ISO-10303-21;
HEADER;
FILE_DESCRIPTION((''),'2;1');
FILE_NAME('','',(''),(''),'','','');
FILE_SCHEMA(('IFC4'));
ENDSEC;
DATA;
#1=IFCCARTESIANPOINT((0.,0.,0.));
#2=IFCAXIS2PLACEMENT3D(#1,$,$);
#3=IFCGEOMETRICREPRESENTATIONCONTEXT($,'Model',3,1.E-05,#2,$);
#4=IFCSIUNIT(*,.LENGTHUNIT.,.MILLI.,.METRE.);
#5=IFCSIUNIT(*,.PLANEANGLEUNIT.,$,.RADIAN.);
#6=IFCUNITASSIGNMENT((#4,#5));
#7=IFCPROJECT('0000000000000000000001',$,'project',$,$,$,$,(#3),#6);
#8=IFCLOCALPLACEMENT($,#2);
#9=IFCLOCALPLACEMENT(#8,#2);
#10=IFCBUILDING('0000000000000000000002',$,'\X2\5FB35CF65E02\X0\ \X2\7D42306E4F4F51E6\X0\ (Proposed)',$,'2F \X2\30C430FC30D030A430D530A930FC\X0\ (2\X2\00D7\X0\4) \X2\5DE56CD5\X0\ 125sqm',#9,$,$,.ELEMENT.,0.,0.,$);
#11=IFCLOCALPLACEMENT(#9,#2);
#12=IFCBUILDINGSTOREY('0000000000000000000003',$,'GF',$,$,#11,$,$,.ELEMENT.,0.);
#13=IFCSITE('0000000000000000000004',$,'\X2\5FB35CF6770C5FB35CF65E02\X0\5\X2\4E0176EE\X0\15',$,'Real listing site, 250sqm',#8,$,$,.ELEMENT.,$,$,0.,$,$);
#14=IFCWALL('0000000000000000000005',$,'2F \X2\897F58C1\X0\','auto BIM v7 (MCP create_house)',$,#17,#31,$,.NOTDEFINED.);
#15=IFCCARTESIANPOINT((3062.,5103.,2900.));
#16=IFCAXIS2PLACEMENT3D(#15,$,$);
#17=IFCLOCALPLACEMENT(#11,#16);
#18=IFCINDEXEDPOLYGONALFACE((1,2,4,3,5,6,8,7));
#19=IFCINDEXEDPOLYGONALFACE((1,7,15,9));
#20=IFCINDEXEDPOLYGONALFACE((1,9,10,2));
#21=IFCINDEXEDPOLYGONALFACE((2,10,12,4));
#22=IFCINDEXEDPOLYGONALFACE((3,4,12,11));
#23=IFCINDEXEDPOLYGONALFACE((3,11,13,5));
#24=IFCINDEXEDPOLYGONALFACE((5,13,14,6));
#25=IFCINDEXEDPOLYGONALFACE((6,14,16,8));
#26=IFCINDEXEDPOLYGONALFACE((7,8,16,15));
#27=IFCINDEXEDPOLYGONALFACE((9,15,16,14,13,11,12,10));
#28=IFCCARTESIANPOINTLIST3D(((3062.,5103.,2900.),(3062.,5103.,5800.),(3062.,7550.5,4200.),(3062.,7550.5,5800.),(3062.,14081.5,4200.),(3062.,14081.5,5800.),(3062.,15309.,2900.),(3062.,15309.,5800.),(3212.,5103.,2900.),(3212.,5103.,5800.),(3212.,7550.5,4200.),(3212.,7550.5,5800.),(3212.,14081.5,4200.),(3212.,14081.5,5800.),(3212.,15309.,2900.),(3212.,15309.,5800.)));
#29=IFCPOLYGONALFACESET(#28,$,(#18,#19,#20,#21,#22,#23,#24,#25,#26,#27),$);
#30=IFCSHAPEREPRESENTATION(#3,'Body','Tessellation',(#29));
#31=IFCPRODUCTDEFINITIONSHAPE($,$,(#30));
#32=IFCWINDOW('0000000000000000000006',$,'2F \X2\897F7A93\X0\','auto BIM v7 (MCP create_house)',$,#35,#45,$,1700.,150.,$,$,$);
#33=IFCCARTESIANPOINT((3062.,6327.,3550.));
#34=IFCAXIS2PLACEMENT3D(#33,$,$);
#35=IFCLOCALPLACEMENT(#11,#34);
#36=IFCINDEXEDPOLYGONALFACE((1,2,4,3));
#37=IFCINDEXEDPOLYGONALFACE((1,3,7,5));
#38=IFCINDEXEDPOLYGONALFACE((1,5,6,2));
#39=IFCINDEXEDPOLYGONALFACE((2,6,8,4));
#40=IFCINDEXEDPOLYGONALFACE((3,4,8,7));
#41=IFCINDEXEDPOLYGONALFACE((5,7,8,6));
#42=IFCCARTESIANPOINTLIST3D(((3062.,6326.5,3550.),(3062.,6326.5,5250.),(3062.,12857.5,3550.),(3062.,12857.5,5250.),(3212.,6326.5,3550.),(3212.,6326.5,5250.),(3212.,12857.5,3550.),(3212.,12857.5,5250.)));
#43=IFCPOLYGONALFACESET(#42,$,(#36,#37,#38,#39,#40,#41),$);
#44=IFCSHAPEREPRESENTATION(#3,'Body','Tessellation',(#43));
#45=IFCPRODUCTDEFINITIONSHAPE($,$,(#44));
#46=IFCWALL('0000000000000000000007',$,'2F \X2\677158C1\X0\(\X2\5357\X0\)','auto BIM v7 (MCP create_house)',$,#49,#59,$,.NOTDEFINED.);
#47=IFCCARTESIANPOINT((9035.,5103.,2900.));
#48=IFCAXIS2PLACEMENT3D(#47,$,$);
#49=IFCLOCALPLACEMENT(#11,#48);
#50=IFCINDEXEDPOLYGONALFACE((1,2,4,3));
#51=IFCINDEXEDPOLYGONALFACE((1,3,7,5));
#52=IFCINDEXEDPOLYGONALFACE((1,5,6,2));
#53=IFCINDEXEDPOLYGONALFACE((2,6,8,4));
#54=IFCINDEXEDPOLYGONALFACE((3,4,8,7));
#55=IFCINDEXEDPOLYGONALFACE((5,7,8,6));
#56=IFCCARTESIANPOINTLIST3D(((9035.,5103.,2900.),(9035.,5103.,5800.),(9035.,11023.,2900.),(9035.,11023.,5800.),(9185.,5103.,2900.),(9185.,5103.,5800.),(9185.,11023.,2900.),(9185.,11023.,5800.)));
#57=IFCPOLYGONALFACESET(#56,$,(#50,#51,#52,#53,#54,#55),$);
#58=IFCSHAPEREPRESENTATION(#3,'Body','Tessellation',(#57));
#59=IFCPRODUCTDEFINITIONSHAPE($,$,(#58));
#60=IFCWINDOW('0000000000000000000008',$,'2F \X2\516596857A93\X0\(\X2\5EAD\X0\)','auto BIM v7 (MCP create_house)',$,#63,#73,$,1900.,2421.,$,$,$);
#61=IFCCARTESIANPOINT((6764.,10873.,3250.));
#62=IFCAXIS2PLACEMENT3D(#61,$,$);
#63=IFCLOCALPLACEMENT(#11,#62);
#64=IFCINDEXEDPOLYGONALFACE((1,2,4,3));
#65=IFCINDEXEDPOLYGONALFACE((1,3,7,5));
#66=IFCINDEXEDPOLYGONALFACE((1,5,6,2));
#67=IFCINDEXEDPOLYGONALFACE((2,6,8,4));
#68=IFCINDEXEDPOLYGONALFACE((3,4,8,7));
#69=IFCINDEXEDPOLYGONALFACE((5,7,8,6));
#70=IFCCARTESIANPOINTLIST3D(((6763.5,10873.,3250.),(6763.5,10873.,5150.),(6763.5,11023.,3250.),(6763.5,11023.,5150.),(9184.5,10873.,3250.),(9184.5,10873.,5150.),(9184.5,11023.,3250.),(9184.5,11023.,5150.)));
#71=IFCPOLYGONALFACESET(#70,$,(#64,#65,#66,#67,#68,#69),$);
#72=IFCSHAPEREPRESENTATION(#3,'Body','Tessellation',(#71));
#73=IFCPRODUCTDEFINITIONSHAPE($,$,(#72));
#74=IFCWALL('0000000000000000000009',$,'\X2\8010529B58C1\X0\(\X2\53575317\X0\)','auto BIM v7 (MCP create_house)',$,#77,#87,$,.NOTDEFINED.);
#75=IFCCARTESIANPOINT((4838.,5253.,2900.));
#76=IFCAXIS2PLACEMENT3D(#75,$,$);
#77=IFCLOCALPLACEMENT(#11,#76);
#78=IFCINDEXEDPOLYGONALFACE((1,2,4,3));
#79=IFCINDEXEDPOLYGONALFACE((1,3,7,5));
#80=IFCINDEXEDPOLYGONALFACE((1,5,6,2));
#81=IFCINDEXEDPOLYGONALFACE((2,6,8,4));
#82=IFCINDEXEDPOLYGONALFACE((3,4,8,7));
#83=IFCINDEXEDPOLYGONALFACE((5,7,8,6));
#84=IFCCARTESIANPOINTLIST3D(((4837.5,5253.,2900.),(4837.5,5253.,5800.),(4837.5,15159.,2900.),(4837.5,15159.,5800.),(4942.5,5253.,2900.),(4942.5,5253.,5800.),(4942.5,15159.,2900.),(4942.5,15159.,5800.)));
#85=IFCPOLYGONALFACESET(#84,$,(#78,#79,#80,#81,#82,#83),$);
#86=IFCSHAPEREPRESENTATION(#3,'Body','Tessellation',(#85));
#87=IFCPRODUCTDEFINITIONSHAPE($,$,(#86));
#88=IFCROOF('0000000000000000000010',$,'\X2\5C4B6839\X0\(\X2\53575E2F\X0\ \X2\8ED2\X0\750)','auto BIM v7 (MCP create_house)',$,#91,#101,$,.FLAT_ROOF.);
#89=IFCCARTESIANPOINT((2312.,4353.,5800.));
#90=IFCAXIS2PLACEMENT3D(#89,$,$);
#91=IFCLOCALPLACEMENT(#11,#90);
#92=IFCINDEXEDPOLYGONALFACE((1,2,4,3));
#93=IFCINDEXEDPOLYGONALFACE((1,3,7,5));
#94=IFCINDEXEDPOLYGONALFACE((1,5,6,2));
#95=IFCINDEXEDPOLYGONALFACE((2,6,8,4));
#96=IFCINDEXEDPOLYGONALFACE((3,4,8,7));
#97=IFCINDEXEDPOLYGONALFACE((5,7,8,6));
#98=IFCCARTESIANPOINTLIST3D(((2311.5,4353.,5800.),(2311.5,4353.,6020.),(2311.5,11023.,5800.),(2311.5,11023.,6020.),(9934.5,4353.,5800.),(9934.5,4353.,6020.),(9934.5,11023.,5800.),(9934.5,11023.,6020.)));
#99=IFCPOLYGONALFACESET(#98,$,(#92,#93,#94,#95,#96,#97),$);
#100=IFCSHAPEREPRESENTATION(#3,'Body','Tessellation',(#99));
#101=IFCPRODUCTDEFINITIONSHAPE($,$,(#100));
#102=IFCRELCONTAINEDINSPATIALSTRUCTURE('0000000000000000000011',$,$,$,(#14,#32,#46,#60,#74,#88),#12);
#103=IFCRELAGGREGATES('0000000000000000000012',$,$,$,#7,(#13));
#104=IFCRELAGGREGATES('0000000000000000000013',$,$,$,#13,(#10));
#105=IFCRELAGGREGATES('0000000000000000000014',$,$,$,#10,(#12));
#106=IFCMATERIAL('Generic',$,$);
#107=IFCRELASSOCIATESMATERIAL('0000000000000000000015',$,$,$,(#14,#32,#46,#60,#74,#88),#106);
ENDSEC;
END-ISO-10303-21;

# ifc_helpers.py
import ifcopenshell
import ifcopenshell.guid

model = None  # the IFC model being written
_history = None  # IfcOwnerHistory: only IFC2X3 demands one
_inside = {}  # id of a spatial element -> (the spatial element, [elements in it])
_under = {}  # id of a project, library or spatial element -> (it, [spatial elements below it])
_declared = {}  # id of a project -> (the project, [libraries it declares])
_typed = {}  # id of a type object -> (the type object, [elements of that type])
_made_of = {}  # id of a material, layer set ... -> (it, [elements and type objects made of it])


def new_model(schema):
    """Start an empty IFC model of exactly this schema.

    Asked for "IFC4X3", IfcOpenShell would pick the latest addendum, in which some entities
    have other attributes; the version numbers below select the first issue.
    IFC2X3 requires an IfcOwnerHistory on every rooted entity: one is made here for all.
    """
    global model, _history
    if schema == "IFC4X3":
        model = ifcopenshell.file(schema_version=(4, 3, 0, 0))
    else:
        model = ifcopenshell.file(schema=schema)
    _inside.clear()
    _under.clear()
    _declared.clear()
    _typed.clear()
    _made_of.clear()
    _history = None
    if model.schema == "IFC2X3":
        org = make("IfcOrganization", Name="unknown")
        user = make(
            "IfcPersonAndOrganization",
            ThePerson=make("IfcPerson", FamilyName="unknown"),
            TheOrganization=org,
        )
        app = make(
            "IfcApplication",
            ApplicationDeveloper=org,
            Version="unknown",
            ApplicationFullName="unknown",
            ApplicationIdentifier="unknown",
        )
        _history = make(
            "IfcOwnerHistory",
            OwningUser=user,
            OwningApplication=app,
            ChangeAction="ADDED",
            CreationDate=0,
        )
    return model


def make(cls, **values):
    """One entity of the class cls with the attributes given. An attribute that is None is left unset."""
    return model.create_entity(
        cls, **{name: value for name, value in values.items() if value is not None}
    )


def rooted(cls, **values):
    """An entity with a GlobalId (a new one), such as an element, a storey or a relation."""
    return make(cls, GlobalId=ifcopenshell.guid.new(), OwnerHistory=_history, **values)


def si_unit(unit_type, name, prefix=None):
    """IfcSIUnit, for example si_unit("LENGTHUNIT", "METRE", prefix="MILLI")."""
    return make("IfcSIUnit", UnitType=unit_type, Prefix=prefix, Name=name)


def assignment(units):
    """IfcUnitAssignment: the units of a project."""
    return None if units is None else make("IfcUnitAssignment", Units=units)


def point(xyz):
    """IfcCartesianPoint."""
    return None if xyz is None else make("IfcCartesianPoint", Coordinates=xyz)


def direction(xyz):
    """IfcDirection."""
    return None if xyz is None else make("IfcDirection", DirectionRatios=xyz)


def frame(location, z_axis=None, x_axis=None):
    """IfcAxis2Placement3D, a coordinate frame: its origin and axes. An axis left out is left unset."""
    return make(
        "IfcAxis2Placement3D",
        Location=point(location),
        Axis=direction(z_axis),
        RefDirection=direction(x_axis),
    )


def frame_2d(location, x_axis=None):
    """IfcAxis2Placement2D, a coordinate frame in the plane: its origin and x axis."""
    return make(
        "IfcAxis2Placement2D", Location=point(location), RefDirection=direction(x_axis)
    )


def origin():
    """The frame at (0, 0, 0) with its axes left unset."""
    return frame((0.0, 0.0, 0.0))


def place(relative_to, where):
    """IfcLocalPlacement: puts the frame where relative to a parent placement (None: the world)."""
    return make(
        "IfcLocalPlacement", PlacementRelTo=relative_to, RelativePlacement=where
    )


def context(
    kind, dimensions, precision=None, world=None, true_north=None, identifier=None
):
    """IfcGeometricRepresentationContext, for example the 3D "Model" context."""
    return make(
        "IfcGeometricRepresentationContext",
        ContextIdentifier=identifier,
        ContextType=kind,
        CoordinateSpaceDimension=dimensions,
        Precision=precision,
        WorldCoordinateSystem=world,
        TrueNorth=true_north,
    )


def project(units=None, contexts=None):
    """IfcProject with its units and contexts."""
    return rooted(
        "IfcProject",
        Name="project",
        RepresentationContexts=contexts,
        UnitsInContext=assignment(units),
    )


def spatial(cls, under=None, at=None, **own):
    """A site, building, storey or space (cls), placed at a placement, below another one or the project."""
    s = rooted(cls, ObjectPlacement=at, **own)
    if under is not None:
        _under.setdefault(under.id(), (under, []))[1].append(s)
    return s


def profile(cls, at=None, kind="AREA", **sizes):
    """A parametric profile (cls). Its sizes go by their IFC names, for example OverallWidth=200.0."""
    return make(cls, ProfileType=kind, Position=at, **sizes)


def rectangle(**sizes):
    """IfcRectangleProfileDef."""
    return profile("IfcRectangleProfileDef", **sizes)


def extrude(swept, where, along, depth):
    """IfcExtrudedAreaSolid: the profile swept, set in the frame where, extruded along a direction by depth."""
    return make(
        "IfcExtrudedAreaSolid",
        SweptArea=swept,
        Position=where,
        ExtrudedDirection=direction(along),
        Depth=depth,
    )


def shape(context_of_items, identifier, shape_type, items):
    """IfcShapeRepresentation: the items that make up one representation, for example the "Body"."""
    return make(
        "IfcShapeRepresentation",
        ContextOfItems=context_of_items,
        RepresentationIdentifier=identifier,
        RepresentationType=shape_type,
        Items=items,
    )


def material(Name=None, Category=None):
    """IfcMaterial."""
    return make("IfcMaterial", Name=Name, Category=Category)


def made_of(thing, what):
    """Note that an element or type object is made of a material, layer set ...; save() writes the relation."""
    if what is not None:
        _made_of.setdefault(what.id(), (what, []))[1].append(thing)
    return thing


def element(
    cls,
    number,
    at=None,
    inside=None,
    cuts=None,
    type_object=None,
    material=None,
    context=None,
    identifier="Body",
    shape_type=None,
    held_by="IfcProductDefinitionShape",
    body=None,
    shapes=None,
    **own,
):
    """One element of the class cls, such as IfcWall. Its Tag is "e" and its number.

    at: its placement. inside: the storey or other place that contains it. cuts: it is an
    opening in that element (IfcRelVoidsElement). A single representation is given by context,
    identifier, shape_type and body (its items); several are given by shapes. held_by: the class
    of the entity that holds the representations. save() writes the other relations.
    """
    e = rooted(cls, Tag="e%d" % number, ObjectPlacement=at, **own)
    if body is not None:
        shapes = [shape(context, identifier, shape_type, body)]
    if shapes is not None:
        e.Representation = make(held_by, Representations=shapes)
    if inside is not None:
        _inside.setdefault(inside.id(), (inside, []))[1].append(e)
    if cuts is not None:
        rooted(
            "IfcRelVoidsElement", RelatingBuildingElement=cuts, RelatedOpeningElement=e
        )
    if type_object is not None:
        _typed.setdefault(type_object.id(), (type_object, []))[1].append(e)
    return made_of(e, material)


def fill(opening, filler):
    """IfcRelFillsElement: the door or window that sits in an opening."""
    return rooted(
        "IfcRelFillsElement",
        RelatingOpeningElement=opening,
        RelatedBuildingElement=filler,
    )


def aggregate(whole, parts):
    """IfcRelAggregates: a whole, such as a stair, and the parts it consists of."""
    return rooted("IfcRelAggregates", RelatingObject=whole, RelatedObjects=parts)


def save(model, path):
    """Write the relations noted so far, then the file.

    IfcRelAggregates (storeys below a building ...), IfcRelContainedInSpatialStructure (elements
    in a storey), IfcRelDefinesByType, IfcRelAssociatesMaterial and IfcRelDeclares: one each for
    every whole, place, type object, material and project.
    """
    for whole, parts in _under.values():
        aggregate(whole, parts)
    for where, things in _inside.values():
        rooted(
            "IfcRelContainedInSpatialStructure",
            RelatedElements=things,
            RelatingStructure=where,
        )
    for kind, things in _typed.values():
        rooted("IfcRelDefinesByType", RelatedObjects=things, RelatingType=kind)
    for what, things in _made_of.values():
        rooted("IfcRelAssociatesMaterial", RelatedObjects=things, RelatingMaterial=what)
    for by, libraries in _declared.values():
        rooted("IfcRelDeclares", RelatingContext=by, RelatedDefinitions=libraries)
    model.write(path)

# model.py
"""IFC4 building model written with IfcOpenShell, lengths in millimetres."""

from ifc_helpers import new_model, si_unit, frame, frame_2d, origin, place, context, project, spatial, rectangle, extrude, material, element, fill, save


model = new_model("IFC4")

# Units and contexts
model_context = context("Model", 3, precision=1e-05, world=origin())
ifc_project = project(units=[si_unit("LENGTHUNIT", "METRE", prefix="MILLI"), si_unit("PLANEANGLEUNIT", "RADIAN")], contexts=[model_context])

# Site, building, storey
site_placement = place(None, origin())
site = spatial("IfcSite", under=ifc_project, at=site_placement, Name="徳島県徳島市5丁目15", ObjectType="Real listing site, 250sqm", CompositionType="ELEMENT", RefElevation=0.0)
building_placement = place(site_placement, origin())
building = spatial("IfcBuilding", under=site, at=building_placement, Name="徳島市 終の住処 (Proposed)", ObjectType="2F ツーバイフォー (2×4) 工法 125sqm", CompositionType="ELEMENT", ElevationOfRefHeight=0.0, ElevationOfTerrain=0.0)
storey_placement = place(building_placement, origin())
storey = spatial("IfcBuildingStorey", under=building, at=storey_placement, Name="GF", CompositionType="ELEMENT", Elevation=0.0)

# Shared definitions
ifc_material = material(Name="Generic")

# Walls, openings, windows
wall_1_placement = place(storey_placement, frame((3062.0, 5103.0, 2900.0)))
wall_1 = element("IfcWall", 1, at=wall_1_placement, inside=storey, material=ifc_material, Name="2F 西壁", Description="auto BIM v7 (MCP create_house)", PredefinedType="NOTDEFINED", context=model_context, shape_type="SweptSolid", body=[
    extrude(rectangle(XDim=150.0, YDim=10206.0, at=frame_2d((75.0, 5103.0))), frame((3062.0, 5103.0, 2900.0)), (0.0, 0.0, 1.0), 2900.0),
])
opening_1_placement = place(storey_placement, frame((3062.0, 6327.0, 3550.0)))
opening_1 = element("IfcOpeningElement", 2, at=opening_1_placement, cuts=wall_1, PredefinedType="NOTDEFINED", context=model_context, shape_type="SweptSolid", body=[
    extrude(rectangle(XDim=150.0, YDim=6531.0, at=frame_2d((75.0, 3265.0))), frame((3062.0, 6327.0, 3550.0)), (0.0, 0.0, 1.0), 1700.0),
])
window_1_placement = place(storey_placement, frame((3062.0, 6327.0, 3550.0)))
window_1 = element("IfcWindow", 3, at=window_1_placement, inside=storey, material=ifc_material, Name="2F 西窓", Description="auto BIM v7 (MCP create_house)", OverallHeight=1700.0, OverallWidth=150.0, context=model_context, shape_type="SweptSolid", body=[
    extrude(rectangle(XDim=150.0, YDim=6531.0, at=frame_2d((75.0, 3265.0))), frame((3062.0, 6327.0, 3550.0)), (0.0, 0.0, 1.0), 1700.0),
])
fill(opening_1, window_1)
wall_2_placement = place(storey_placement, frame((9035.0, 5103.0, 2900.0)))
wall_2 = element("IfcWall", 4, at=wall_2_placement, inside=storey, material=ifc_material, Name="2F 東壁(南)", Description="auto BIM v7 (MCP create_house)", PredefinedType="NOTDEFINED", context=model_context, shape_type="SweptSolid", body=[
    extrude(rectangle(XDim=150.0, YDim=5920.0, at=frame_2d((75.0, 2960.0))), frame((9035.0, 5103.0, 2900.0)), (0.0, 0.0, 1.0), 2900.0),
])
opening_2_placement = place(storey_placement, frame((6764.0, 10873.0, 3250.0)))
opening_2 = element("IfcOpeningElement", 5, at=opening_2_placement, cuts=wall_2, PredefinedType="NOTDEFINED", context=model_context, shape_type="SweptSolid", body=[
    extrude(rectangle(XDim=2421.0, YDim=150.0, at=frame_2d((1210.0, 75.0))), frame((6764.0, 10873.0, 3250.0)), (0.0, 0.0, 1.0), 1900.0),
])
window_2_placement = place(storey_placement, frame((6764.0, 10873.0, 3250.0)))
window_2 = element("IfcWindow", 6, at=window_2_placement, inside=storey, material=ifc_material, Name="2F 入隅窓(庭)", Description="auto BIM v7 (MCP create_house)", OverallHeight=1900.0, OverallWidth=2421.0, context=model_context, shape_type="SweptSolid", body=[
    extrude(rectangle(XDim=2421.0, YDim=150.0, at=frame_2d((1210.0, 75.0))), frame((6764.0, 10873.0, 3250.0)), (0.0, 0.0, 1.0), 1900.0),
])
fill(opening_2, window_2)

# Wall
wall_3_placement = place(storey_placement, frame((4838.0, 5253.0, 2900.0)))
element("IfcWall", 7, at=wall_3_placement, inside=storey, material=ifc_material, Name="耐力壁(南北)", Description="auto BIM v7 (MCP create_house)", PredefinedType="NOTDEFINED", context=model_context, shape_type="SweptSolid", body=[
    extrude(rectangle(XDim=105.0, YDim=9906.0, at=frame_2d((52.0, 4953.0))), frame((4838.0, 5253.0, 2900.0)), (0.0, 0.0, 1.0), 2900.0),
])

# Roof
for number, where, name in (
    (8, (2312.0, 4353.0, 5800.0), "屋根(南帯 軒750)"),
):
    element("IfcRoof", number, at=place(storey_placement, frame(where)), inside=storey, material=ifc_material, Name=name, Description="auto BIM v7 (MCP create_house)", PredefinedType="FLAT_ROOF", context=model_context, shape_type="SweptSolid", body=[
        extrude(rectangle(XDim=7623.0, YDim=6670.0, at=frame_2d((3811.0, 3335.0))), frame((2312.0, 4353.0, 5800.0)), (0.0, 0.0, 1.0), 220.0),
    ])

save(model, "model.ifc")
